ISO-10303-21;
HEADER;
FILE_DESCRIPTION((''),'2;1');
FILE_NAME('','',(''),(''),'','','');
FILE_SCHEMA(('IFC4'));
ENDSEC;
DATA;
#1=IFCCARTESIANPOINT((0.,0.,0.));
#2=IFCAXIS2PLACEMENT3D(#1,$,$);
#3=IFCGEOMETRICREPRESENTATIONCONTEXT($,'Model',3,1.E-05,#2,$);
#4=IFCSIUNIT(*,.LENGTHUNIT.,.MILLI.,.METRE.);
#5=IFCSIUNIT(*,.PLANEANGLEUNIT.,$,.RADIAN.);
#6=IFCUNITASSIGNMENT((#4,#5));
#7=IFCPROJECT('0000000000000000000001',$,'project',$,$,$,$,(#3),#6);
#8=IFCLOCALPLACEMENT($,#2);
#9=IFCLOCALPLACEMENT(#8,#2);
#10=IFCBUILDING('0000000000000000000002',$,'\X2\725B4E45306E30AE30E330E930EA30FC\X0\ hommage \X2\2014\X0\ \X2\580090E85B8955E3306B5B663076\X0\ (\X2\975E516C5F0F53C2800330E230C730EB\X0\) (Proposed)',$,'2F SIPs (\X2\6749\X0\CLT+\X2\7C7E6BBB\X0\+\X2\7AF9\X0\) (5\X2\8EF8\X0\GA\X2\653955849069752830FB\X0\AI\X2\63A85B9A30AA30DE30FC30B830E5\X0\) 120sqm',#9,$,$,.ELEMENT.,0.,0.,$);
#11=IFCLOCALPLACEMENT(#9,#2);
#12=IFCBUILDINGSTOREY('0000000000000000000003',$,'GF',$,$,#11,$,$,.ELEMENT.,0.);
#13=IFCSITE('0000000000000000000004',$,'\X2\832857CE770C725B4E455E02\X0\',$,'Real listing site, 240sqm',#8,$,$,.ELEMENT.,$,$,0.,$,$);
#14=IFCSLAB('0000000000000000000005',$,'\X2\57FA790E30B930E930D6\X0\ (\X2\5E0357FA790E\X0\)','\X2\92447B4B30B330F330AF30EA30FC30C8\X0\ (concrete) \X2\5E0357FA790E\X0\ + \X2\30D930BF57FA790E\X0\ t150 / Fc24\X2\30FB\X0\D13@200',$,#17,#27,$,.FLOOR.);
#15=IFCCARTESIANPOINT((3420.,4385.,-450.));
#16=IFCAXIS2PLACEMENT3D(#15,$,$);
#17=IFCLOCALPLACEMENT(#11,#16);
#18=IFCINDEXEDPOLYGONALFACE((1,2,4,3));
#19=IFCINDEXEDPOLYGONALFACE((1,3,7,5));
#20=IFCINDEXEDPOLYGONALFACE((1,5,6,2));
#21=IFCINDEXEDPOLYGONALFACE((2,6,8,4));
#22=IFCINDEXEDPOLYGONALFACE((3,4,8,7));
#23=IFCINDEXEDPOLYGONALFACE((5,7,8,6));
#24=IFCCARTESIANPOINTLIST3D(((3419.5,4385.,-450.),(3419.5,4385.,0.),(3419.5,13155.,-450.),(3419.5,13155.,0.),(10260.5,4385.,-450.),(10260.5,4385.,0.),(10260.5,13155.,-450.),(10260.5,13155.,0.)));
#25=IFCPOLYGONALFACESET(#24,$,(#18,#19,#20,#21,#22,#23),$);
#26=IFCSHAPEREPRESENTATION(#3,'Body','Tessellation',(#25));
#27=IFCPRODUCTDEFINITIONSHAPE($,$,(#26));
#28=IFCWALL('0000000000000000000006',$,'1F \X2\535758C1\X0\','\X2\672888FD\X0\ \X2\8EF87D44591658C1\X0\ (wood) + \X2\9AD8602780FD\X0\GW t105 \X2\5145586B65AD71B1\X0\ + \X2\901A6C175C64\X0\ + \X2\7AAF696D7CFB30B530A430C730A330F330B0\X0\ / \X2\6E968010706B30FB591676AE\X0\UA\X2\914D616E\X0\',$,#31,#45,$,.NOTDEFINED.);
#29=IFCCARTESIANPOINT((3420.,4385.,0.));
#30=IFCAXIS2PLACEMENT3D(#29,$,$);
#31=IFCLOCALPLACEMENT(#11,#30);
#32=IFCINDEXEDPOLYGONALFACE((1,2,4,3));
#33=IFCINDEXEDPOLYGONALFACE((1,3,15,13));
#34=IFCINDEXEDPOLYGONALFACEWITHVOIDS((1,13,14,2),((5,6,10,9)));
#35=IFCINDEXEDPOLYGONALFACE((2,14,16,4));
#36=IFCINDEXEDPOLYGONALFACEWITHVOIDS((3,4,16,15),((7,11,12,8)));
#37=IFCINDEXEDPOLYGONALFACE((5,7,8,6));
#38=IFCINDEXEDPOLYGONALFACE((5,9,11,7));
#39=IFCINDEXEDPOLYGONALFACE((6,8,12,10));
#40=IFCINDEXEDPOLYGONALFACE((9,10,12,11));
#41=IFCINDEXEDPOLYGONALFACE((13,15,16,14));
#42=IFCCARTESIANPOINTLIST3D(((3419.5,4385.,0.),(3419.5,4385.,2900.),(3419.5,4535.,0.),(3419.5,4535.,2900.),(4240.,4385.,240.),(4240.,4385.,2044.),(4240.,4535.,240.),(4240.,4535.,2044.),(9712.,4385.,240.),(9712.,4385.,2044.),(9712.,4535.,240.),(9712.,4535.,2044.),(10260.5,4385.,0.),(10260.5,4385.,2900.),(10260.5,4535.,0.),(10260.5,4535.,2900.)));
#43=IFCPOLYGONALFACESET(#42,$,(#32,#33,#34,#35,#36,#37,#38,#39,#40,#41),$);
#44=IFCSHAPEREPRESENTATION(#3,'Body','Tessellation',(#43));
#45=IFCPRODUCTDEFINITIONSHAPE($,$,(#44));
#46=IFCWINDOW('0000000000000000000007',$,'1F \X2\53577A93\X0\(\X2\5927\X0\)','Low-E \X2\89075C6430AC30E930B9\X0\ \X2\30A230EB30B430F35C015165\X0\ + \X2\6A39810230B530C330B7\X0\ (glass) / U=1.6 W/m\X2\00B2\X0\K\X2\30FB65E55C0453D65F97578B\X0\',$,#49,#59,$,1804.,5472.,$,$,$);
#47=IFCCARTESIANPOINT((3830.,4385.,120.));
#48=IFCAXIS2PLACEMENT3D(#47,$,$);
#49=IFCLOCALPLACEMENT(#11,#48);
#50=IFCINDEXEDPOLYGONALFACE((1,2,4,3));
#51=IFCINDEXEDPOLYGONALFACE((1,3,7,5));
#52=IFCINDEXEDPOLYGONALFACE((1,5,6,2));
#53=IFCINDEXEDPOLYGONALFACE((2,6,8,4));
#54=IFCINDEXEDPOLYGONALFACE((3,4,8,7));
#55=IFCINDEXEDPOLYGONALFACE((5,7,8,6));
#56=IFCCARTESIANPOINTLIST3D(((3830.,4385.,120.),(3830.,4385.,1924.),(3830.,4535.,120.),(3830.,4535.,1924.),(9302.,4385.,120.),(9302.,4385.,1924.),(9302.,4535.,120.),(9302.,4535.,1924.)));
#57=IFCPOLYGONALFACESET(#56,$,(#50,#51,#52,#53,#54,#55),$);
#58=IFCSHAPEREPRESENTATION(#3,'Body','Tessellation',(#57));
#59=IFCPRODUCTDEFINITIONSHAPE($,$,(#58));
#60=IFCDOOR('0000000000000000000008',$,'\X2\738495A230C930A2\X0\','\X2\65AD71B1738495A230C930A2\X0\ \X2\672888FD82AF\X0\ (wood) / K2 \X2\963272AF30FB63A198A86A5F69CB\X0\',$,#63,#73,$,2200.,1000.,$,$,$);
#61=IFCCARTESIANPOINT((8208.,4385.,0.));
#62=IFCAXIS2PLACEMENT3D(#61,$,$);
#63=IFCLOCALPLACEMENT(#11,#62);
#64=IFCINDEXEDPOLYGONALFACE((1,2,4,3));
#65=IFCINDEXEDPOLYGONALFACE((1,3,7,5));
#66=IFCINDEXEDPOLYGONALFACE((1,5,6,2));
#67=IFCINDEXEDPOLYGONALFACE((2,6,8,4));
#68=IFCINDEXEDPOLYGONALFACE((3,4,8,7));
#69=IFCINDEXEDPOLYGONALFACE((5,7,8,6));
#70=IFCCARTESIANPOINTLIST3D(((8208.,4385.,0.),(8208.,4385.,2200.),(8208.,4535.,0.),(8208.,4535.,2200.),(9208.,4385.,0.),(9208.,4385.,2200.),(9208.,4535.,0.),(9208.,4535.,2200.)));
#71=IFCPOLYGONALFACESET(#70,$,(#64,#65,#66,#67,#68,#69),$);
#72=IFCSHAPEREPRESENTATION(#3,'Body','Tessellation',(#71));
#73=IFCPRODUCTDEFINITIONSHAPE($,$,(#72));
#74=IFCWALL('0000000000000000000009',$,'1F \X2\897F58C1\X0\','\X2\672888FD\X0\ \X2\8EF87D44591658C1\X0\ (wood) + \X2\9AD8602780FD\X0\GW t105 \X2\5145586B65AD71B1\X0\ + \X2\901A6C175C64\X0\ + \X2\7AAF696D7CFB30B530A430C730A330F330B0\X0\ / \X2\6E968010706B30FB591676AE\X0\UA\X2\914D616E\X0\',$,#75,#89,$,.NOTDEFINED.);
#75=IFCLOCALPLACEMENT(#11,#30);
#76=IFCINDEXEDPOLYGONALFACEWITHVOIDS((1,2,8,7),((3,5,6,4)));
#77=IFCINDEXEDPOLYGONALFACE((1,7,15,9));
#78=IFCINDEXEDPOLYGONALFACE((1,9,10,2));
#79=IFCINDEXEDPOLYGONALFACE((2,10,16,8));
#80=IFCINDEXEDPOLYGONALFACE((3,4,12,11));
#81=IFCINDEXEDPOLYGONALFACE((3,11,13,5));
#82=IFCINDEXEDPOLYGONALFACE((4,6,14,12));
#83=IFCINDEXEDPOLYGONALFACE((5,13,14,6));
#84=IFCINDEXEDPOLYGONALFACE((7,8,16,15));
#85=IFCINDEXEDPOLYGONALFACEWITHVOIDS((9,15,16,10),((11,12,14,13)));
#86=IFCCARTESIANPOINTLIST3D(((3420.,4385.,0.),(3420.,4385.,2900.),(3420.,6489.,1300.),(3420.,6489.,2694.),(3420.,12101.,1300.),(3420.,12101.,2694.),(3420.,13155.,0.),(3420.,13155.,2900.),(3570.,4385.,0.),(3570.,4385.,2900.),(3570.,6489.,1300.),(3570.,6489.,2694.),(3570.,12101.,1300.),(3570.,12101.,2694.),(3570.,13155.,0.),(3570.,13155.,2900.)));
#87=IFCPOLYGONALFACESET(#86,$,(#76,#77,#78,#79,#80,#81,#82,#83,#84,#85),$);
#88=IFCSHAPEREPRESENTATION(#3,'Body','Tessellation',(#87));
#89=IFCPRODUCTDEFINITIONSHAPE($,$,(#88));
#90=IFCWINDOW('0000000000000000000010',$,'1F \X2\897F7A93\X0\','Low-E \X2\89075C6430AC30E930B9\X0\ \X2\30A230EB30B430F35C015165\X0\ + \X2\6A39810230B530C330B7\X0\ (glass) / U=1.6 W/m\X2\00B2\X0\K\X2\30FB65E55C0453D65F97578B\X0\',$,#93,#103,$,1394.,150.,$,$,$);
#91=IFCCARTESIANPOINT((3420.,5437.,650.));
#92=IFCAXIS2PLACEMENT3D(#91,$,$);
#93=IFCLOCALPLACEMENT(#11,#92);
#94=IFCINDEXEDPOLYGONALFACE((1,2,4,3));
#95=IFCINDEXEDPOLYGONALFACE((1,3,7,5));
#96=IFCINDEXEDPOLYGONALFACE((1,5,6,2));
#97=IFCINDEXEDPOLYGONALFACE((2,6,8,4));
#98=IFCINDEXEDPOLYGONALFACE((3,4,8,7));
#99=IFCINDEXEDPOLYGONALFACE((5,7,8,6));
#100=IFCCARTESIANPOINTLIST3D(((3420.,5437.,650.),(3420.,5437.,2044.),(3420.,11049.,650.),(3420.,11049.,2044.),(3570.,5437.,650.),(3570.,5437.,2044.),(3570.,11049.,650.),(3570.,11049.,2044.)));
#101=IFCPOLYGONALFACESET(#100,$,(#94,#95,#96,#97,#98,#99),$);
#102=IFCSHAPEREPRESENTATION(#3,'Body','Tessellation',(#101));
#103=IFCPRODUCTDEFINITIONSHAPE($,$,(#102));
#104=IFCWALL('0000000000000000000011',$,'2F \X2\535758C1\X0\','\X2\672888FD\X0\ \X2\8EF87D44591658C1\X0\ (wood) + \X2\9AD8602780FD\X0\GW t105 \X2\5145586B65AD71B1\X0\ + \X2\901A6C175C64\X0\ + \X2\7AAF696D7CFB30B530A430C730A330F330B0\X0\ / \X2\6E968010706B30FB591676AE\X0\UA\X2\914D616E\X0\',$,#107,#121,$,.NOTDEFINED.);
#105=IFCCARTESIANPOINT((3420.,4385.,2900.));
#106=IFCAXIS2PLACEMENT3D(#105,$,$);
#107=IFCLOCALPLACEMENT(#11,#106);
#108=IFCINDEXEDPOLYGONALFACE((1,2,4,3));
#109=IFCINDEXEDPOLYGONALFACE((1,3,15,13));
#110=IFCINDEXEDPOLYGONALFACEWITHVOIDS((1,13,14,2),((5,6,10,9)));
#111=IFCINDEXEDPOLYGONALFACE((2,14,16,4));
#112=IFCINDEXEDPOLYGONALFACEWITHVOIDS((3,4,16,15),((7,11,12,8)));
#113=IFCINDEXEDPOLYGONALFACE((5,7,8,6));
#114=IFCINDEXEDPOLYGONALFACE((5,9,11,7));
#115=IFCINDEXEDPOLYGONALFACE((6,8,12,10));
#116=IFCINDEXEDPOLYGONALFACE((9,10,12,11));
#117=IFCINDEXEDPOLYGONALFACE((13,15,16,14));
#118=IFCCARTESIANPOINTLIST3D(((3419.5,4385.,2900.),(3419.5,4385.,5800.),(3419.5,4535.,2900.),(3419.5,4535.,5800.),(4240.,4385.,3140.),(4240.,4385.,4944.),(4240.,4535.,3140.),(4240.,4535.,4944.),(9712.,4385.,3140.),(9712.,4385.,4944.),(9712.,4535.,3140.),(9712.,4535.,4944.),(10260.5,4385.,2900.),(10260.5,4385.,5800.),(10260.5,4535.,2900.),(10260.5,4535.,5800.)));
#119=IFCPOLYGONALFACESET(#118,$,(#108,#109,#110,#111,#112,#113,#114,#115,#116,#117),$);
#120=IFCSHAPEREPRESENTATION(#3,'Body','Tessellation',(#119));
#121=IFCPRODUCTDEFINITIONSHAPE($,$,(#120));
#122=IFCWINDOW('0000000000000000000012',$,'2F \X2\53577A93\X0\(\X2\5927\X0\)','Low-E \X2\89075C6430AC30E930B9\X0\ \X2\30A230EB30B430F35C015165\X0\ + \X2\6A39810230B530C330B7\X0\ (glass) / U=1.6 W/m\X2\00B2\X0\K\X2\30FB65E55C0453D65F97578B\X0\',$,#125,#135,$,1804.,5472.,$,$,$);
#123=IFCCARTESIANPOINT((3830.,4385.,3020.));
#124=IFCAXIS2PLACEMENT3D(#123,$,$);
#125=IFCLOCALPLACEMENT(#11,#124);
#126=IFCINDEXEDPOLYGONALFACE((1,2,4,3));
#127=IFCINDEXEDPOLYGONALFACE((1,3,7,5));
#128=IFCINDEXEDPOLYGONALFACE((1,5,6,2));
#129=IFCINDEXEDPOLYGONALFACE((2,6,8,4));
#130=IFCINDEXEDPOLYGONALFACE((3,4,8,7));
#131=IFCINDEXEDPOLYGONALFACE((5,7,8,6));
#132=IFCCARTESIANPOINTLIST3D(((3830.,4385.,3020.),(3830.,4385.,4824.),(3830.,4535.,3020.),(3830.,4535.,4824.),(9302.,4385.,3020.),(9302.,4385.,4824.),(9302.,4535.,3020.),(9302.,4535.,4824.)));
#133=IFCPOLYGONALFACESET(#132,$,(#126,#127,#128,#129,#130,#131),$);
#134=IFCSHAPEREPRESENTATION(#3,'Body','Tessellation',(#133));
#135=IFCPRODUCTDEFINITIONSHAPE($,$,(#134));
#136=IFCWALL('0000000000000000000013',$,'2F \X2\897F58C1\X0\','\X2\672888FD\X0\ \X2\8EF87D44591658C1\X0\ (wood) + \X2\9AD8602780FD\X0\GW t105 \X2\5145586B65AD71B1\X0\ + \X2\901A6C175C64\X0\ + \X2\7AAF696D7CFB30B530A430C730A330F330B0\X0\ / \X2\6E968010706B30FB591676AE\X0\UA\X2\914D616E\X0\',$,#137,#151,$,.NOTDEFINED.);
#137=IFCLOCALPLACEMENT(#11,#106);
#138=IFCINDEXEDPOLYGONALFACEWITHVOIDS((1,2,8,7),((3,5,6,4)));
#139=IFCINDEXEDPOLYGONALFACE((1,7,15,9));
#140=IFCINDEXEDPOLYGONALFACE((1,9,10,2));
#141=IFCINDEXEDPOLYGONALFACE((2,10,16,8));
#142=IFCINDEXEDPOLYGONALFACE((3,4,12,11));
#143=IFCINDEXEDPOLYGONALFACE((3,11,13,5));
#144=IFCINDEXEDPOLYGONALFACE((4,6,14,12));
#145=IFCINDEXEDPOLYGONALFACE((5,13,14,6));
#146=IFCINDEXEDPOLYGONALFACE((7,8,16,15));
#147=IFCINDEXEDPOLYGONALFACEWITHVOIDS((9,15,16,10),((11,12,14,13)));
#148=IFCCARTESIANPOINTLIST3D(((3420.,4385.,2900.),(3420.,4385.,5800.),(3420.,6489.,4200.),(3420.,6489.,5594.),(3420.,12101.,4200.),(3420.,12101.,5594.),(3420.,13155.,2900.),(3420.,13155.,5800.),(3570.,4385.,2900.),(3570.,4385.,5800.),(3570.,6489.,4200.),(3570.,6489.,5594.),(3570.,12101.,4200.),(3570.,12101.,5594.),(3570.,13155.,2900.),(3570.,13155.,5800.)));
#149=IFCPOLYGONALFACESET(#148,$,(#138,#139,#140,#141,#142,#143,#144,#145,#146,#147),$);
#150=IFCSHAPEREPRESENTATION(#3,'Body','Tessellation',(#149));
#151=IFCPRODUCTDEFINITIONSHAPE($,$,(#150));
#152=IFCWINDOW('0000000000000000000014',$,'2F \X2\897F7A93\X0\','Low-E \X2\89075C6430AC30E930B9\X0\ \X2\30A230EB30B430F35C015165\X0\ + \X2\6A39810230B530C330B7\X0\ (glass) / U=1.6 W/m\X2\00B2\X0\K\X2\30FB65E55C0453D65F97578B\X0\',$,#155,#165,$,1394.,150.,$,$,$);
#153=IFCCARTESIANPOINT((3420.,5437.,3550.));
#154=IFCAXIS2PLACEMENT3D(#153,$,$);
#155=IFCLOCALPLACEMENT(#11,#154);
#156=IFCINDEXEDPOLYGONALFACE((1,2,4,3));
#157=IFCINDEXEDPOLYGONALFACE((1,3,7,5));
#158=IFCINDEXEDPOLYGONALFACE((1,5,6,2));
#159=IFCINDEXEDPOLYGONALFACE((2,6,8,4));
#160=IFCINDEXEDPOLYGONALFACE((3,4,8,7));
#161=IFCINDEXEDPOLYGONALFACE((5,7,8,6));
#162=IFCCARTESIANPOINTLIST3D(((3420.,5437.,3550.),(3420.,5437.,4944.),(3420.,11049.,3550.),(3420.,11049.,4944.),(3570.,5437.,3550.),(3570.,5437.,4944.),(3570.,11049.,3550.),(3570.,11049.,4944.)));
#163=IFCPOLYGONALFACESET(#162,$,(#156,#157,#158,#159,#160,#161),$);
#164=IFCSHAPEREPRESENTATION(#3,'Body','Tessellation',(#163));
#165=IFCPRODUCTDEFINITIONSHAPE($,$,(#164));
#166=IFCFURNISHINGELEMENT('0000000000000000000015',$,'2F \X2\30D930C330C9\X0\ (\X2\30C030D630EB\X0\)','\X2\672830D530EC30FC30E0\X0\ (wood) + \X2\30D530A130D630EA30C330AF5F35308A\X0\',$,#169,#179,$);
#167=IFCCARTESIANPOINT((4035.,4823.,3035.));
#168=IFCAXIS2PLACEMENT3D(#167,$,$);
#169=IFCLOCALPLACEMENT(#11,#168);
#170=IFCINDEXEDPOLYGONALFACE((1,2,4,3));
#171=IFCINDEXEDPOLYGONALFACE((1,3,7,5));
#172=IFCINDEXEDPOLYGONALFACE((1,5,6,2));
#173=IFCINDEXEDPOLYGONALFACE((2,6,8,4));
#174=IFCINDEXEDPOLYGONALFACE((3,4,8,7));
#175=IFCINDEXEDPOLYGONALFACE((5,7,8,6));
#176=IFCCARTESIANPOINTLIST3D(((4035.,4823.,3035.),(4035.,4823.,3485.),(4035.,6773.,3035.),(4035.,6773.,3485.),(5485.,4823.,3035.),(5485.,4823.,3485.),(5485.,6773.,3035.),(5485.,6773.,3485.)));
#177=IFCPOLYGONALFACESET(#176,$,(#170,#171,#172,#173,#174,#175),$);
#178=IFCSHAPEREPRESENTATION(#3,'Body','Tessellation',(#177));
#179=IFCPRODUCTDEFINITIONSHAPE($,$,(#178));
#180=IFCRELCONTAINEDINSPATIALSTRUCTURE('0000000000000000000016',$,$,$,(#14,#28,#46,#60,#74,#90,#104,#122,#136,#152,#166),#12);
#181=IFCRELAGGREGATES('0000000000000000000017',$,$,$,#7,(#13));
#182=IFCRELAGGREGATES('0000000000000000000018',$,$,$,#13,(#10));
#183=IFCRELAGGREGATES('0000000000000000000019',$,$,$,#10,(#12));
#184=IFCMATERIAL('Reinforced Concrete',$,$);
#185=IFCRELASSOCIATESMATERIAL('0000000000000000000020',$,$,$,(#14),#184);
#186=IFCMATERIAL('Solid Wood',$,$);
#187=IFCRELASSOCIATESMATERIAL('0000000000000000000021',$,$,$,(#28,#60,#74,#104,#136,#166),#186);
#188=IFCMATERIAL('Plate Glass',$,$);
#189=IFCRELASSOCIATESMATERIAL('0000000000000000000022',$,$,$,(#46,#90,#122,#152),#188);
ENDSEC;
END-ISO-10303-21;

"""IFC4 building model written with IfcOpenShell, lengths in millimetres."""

from ifc_helpers import new_model, si_unit, frame, frame_2d, origin, place, context, project, spatial, rectangle, extrude, material, element, fill, save


model = new_model("IFC4")

# Units and contexts
model_context = context("Model", 3, precision=1e-05, world=origin())
ifc_project = project(units=[si_unit("LENGTHUNIT", "METRE", prefix="MILLI"), si_unit("PLANEANGLEUNIT", "RADIAN")], contexts=[model_context])

# Site, building, storey
site_placement = place(None, origin())
site = spatial("IfcSite", under=ifc_project, at=site_placement, Name="茨城県牛久市", ObjectType="Real listing site, 240sqm", CompositionType="ELEMENT", RefElevation=0.0)
building_placement = place(site_placement, origin())
building = spatial("IfcBuilding", under=site, at=building_placement, Name="牛久のギャラリー hommage — 堀部安嗣に学ぶ (非公式参考モデル) (Proposed)", ObjectType="2F SIPs (杉CLT+籾殻+竹) (5軸GA改善適用・AI推定オマージュ) 120sqm", CompositionType="ELEMENT", ElevationOfRefHeight=0.0, ElevationOfTerrain=0.0)
storey_placement = place(building_placement, origin())
storey = spatial("IfcBuildingStorey", under=building, at=storey_placement, Name="GF", CompositionType="ELEMENT", Elevation=0.0)

# Slab
ifc_material_1 = material(Name="Reinforced Concrete")
slab_1_placement = place(storey_placement, frame((3420.0, 4385.0, -450.0)))
element("IfcSlab", 1, at=slab_1_placement, inside=storey, material=ifc_material_1, Name="基礎スラブ (布基礎)", Description="鉄筋コンクリート (concrete) 布基礎 + ベタ基礎 t150 / Fc24・D13@200", PredefinedType="FLOOR", context=model_context, shape_type="SweptSolid", body=[
    extrude(rectangle(XDim=6841.0, YDim=8770.0, at=frame_2d((3420.0, 4385.0))), frame((3420.0, 4385.0, -450.0)), (0.0, 0.0, 1.0), 450.0),
])
ifc_material_2 = material(Name="Solid Wood")

# Wall, openings, window, door
wall_1_placement = place(storey_placement, frame((3420.0, 4385.0, 0.0)))
wall_1 = element("IfcWall", 2, at=wall_1_placement, inside=storey, material=ifc_material_2, Name="1F 南壁", Description="木製 軸組外壁 (wood) + 高性能GW t105 充填断熱 + 通気層 + 窯業系サイディング / 準耐火・外皮UA配慮", PredefinedType="NOTDEFINED", context=model_context, shape_type="SweptSolid", body=[
    extrude(rectangle(XDim=6841.0, YDim=150.0, at=frame_2d((3420.0, 75.0))), frame((3420.0, 4385.0, 0.0)), (0.0, 0.0, 1.0), 2900.0),
])
opening_1_placement = place(storey_placement, frame((3830.0, 4385.0, 120.0)))
opening_1 = element("IfcOpeningElement", 3, at=opening_1_placement, cuts=wall_1, PredefinedType="NOTDEFINED", context=model_context, shape_type="SweptSolid", body=[
    extrude(rectangle(XDim=5472.0, YDim=150.0, at=frame_2d((2736.0, 75.0))), frame((3830.0, 4385.0, 120.0)), (0.0, 0.0, 1.0), 1804.0),
])
opening_2_placement = place(storey_placement, frame((8208.0, 4385.0, 0.0)))
opening_2 = element("IfcOpeningElement", 4, at=opening_2_placement, cuts=wall_1, PredefinedType="NOTDEFINED", context=model_context, shape_type="SweptSolid", body=[
    extrude(rectangle(XDim=1000.0, YDim=150.0, at=frame_2d((500.0, 75.0))), frame((8208.0, 4385.0, 0.0)), (0.0, 0.0, 1.0), 2200.0),
])
ifc_material_3 = material(Name="Plate Glass")
window_1_placement = place(storey_placement, frame((3830.0, 4385.0, 120.0)))
window_1 = element("IfcWindow", 5, at=window_1_placement, inside=storey, material=ifc_material_3, Name="1F 南窓(大)", Description="Low-E 複層ガラス アルゴン封入 + 樹脂サッシ (glass) / U=1.6 W/m²K・日射取得型", OverallHeight=1804.0, OverallWidth=5472.0, context=model_context, shape_type="SweptSolid", body=[
    extrude(rectangle(XDim=5472.0, YDim=150.0, at=frame_2d((2736.0, 75.0))), frame((3830.0, 4385.0, 120.0)), (0.0, 0.0, 1.0), 1804.0),
])
fill(opening_1, window_1)
door_placement = place(storey_placement, frame((8208.0, 4385.0, 0.0)))
door = element("IfcDoor", 6, at=door_placement, inside=storey, material=ifc_material_2, Name="玄関ドア", Description="断熱玄関ドア 木製芯 (wood) / K2 防犯・採風機構", OverallHeight=2200.0, OverallWidth=1000.0, context=model_context, shape_type="SweptSolid", body=[
    extrude(rectangle(XDim=1000.0, YDim=150.0, at=frame_2d((500.0, 75.0))), frame((8208.0, 4385.0, 0.0)), (0.0, 0.0, 1.0), 2200.0),
])
fill(opening_2, door)

# Wall, opening, window
wall_2_placement = place(storey_placement, frame((3420.0, 4385.0, 0.0)))
wall_2 = element("IfcWall", 7, at=wall_2_placement, inside=storey, material=ifc_material_2, Name="1F 西壁", Description="木製 軸組外壁 (wood) + 高性能GW t105 充填断熱 + 通気層 + 窯業系サイディング / 準耐火・外皮UA配慮", PredefinedType="NOTDEFINED", context=model_context, shape_type="SweptSolid", body=[
    extrude(rectangle(XDim=150.0, YDim=8770.0, at=frame_2d((75.0, 4385.0))), frame((3420.0, 4385.0, 0.0)), (0.0, 0.0, 1.0), 2900.0),
])
opening_3_placement = place(storey_placement, frame((3420.0, 5437.0, 650.0)))
opening_3 = element("IfcOpeningElement", 8, at=opening_3_placement, cuts=wall_2, PredefinedType="NOTDEFINED", context=model_context, shape_type="SweptSolid", body=[
    extrude(rectangle(XDim=150.0, YDim=5612.0, at=frame_2d((75.0, 2806.0))), frame((3420.0, 5437.0, 650.0)), (0.0, 0.0, 1.0), 1394.0),
])
window_2_placement = place(storey_placement, frame((3420.0, 5437.0, 650.0)))
window_2 = element("IfcWindow", 9, at=window_2_placement, inside=storey, material=ifc_material_3, Name="1F 西窓", Description="Low-E 複層ガラス アルゴン封入 + 樹脂サッシ (glass) / U=1.6 W/m²K・日射取得型", OverallHeight=1394.0, OverallWidth=150.0, context=model_context, shape_type="SweptSolid", body=[
    extrude(rectangle(XDim=150.0, YDim=5612.0, at=frame_2d((75.0, 2806.0))), frame((3420.0, 5437.0, 650.0)), (0.0, 0.0, 1.0), 1394.0),
])
fill(opening_3, window_2)

# Walls, openings, windows
wall_3_placement = place(storey_placement, frame((3420.0, 4385.0, 2900.0)))
wall_3 = element("IfcWall", 10, at=wall_3_placement, inside=storey, material=ifc_material_2, Name="2F 南壁", Description="木製 軸組外壁 (wood) + 高性能GW t105 充填断熱 + 通気層 + 窯業系サイディング / 準耐火・外皮UA配慮", PredefinedType="NOTDEFINED", context=model_context, shape_type="SweptSolid", body=[
    extrude(rectangle(XDim=6841.0, YDim=150.0, at=frame_2d((3420.0, 75.0))), frame((3420.0, 4385.0, 2900.0)), (0.0, 0.0, 1.0), 2900.0),
])
opening_4_placement = place(storey_placement, frame((3830.0, 4385.0, 3020.0)))
opening_4 = element("IfcOpeningElement", 11, at=opening_4_placement, cuts=wall_3, PredefinedType="NOTDEFINED", context=model_context, shape_type="SweptSolid", body=[
    extrude(rectangle(XDim=5472.0, YDim=150.0, at=frame_2d((2736.0, 75.0))), frame((3830.0, 4385.0, 3020.0)), (0.0, 0.0, 1.0), 1804.0),
])
window_3_placement = place(storey_placement, frame((3830.0, 4385.0, 3020.0)))
window_3 = element("IfcWindow", 12, at=window_3_placement, inside=storey, material=ifc_material_3, Name="2F 南窓(大)", Description="Low-E 複層ガラス アルゴン封入 + 樹脂サッシ (glass) / U=1.6 W/m²K・日射取得型", OverallHeight=1804.0, OverallWidth=5472.0, context=model_context, shape_type="SweptSolid", body=[
    extrude(rectangle(XDim=5472.0, YDim=150.0, at=frame_2d((2736.0, 75.0))), frame((3830.0, 4385.0, 3020.0)), (0.0, 0.0, 1.0), 1804.0),
])
fill(opening_4, window_3)
wall_4_placement = place(storey_placement, frame((3420.0, 4385.0, 2900.0)))
wall_4 = element("IfcWall", 13, at=wall_4_placement, inside=storey, material=ifc_material_2, Name="2F 西壁", Description="木製 軸組外壁 (wood) + 高性能GW t105 充填断熱 + 通気層 + 窯業系サイディング / 準耐火・外皮UA配慮", PredefinedType="NOTDEFINED", context=model_context, shape_type="SweptSolid", body=[
    extrude(rectangle(XDim=150.0, YDim=8770.0, at=frame_2d((75.0, 4385.0))), frame((3420.0, 4385.0, 2900.0)), (0.0, 0.0, 1.0), 2900.0),
])
opening_5_placement = place(storey_placement, frame((3420.0, 5437.0, 3550.0)))
opening_5 = element("IfcOpeningElement", 14, at=opening_5_placement, cuts=wall_4, PredefinedType="NOTDEFINED", context=model_context, shape_type="SweptSolid", body=[
    extrude(rectangle(XDim=150.0, YDim=5612.0, at=frame_2d((75.0, 2806.0))), frame((3420.0, 5437.0, 3550.0)), (0.0, 0.0, 1.0), 1394.0),
])
window_4_placement = place(storey_placement, frame((3420.0, 5437.0, 3550.0)))
window_4 = element("IfcWindow", 15, at=window_4_placement, inside=storey, material=ifc_material_3, Name="2F 西窓", Description="Low-E 複層ガラス アルゴン封入 + 樹脂サッシ (glass) / U=1.6 W/m²K・日射取得型", OverallHeight=1394.0, OverallWidth=150.0, context=model_context, shape_type="SweptSolid", body=[
    extrude(rectangle(XDim=150.0, YDim=5612.0, at=frame_2d((75.0, 2806.0))), frame((3420.0, 5437.0, 3550.0)), (0.0, 0.0, 1.0), 1394.0),
])
fill(opening_5, window_4)

# Furnishing element
furnishing_placement = place(storey_placement, frame((4035.0, 4823.0, 3035.0)))
element("IfcFurnishingElement", 16, at=furnishing_placement, inside=storey, material=ifc_material_2, Name="2F ベッド (ダブル)", Description="木フレーム (wood) + ファブリック張り", context=model_context, shape_type="SweptSolid", body=[
    extrude(rectangle(XDim=1450.0, YDim=1950.0, at=frame_2d((725.0, 975.0))), frame((4035.0, 4823.0, 3035.0)), (0.0, 0.0, 1.0), 450.0),
])

save(model, "model.ifc")
